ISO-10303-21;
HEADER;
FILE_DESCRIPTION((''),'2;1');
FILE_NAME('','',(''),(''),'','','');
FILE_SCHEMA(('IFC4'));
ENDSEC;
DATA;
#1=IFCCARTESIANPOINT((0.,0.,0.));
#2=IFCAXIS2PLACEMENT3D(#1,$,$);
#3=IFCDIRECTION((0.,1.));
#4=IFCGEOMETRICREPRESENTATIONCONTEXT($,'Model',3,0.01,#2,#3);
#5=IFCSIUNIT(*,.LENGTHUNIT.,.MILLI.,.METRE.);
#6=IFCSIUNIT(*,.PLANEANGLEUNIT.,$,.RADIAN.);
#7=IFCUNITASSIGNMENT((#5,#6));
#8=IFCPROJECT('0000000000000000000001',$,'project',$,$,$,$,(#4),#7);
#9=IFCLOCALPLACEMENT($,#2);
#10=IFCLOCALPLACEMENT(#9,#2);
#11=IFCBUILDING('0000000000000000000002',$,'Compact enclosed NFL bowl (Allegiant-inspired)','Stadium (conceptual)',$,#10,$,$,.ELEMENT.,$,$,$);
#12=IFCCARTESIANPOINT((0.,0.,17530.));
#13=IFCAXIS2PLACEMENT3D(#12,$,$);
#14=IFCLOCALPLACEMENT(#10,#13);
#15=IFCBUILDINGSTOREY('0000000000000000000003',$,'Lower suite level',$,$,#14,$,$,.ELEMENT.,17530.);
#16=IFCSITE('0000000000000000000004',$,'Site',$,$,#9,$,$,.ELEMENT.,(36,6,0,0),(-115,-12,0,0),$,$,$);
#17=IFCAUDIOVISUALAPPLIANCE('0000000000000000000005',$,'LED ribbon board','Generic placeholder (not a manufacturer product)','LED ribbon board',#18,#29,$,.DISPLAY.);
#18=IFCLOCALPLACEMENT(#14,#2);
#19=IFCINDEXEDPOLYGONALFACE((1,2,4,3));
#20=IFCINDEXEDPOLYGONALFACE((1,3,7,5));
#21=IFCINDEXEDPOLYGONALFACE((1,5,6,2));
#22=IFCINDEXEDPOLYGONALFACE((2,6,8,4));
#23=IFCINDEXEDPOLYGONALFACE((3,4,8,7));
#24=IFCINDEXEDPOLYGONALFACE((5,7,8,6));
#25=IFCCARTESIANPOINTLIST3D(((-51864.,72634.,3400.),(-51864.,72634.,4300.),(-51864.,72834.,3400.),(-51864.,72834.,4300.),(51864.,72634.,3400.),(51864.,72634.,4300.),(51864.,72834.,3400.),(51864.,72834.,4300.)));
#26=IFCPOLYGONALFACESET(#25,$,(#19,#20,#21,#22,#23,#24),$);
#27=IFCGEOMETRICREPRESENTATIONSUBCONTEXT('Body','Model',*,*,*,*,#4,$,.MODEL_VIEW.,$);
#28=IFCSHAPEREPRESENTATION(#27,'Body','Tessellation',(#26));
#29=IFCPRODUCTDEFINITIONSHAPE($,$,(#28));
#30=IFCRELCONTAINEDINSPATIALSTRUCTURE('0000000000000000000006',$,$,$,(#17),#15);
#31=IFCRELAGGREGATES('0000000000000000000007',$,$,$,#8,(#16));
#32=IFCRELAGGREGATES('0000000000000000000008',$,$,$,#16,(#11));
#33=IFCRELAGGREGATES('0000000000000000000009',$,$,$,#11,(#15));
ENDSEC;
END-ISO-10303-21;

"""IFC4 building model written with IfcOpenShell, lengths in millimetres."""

from ifc_helpers import new_model, si_unit, direction, frame, origin, place, context, subcontext, project, spatial, line, indexed_curve, outline, extrude, element, save


model = new_model("IFC4")

# Units and contexts
model_context = context("Model", 3, precision=0.01, world=origin(), true_north=direction((0.0, 1.0)))
body_context = subcontext(model_context, "Body", "Model", "MODEL_VIEW")
ifc_project = project(units=[si_unit("LENGTHUNIT", "METRE", prefix="MILLI"), si_unit("PLANEANGLEUNIT", "RADIAN")], contexts=[model_context])

# Site, building, storey
site_placement = place(None, origin())
site = spatial("IfcSite", under=ifc_project, at=site_placement, Name="Site", CompositionType="ELEMENT", RefLatitude=(36, 6, 0, 0), RefLongitude=(-115, -12, 0, 0))
building_placement = place(site_placement, origin())
building = spatial("IfcBuilding", under=site, at=building_placement, Name="Compact enclosed NFL bowl (Allegiant-inspired)", Description="Stadium (conceptual)", CompositionType="ELEMENT")
storey_placement = place(building_placement, frame((0.0, 0.0, 17530.0)))
storey = spatial("IfcBuildingStorey", under=building, at=storey_placement, Name="Lower suite level", CompositionType="ELEMENT", Elevation=17530.0)

# Shared definitions
placement = place(storey_placement, frame((0.0, 0.0, -17530.0)))

# Audio visual appliance
element("IfcAudioVisualAppliance", 1, at=placement, inside=storey, Name="LED ribbon board", Description="Generic placeholder (not a manufacturer product)", ObjectType="LED ribbon board", PredefinedType="DISPLAY", context=body_context, shape_type="SweptSolid", body=[
    extrude(outline(indexed_curve([(51864.0, 72634.0), (-51864.0, 72634.0), (-51864.0, 72834.0), (51864.0, 72834.0)], segments=[line(1, 2), line(2, 3), line(3, 4), line(4, 1)], self_intersect=False)), frame((0.0, 0.0, 20930.0)), (0.0, 0.0, 1.0), 900.0),
])

save(model, "model.ifc")
